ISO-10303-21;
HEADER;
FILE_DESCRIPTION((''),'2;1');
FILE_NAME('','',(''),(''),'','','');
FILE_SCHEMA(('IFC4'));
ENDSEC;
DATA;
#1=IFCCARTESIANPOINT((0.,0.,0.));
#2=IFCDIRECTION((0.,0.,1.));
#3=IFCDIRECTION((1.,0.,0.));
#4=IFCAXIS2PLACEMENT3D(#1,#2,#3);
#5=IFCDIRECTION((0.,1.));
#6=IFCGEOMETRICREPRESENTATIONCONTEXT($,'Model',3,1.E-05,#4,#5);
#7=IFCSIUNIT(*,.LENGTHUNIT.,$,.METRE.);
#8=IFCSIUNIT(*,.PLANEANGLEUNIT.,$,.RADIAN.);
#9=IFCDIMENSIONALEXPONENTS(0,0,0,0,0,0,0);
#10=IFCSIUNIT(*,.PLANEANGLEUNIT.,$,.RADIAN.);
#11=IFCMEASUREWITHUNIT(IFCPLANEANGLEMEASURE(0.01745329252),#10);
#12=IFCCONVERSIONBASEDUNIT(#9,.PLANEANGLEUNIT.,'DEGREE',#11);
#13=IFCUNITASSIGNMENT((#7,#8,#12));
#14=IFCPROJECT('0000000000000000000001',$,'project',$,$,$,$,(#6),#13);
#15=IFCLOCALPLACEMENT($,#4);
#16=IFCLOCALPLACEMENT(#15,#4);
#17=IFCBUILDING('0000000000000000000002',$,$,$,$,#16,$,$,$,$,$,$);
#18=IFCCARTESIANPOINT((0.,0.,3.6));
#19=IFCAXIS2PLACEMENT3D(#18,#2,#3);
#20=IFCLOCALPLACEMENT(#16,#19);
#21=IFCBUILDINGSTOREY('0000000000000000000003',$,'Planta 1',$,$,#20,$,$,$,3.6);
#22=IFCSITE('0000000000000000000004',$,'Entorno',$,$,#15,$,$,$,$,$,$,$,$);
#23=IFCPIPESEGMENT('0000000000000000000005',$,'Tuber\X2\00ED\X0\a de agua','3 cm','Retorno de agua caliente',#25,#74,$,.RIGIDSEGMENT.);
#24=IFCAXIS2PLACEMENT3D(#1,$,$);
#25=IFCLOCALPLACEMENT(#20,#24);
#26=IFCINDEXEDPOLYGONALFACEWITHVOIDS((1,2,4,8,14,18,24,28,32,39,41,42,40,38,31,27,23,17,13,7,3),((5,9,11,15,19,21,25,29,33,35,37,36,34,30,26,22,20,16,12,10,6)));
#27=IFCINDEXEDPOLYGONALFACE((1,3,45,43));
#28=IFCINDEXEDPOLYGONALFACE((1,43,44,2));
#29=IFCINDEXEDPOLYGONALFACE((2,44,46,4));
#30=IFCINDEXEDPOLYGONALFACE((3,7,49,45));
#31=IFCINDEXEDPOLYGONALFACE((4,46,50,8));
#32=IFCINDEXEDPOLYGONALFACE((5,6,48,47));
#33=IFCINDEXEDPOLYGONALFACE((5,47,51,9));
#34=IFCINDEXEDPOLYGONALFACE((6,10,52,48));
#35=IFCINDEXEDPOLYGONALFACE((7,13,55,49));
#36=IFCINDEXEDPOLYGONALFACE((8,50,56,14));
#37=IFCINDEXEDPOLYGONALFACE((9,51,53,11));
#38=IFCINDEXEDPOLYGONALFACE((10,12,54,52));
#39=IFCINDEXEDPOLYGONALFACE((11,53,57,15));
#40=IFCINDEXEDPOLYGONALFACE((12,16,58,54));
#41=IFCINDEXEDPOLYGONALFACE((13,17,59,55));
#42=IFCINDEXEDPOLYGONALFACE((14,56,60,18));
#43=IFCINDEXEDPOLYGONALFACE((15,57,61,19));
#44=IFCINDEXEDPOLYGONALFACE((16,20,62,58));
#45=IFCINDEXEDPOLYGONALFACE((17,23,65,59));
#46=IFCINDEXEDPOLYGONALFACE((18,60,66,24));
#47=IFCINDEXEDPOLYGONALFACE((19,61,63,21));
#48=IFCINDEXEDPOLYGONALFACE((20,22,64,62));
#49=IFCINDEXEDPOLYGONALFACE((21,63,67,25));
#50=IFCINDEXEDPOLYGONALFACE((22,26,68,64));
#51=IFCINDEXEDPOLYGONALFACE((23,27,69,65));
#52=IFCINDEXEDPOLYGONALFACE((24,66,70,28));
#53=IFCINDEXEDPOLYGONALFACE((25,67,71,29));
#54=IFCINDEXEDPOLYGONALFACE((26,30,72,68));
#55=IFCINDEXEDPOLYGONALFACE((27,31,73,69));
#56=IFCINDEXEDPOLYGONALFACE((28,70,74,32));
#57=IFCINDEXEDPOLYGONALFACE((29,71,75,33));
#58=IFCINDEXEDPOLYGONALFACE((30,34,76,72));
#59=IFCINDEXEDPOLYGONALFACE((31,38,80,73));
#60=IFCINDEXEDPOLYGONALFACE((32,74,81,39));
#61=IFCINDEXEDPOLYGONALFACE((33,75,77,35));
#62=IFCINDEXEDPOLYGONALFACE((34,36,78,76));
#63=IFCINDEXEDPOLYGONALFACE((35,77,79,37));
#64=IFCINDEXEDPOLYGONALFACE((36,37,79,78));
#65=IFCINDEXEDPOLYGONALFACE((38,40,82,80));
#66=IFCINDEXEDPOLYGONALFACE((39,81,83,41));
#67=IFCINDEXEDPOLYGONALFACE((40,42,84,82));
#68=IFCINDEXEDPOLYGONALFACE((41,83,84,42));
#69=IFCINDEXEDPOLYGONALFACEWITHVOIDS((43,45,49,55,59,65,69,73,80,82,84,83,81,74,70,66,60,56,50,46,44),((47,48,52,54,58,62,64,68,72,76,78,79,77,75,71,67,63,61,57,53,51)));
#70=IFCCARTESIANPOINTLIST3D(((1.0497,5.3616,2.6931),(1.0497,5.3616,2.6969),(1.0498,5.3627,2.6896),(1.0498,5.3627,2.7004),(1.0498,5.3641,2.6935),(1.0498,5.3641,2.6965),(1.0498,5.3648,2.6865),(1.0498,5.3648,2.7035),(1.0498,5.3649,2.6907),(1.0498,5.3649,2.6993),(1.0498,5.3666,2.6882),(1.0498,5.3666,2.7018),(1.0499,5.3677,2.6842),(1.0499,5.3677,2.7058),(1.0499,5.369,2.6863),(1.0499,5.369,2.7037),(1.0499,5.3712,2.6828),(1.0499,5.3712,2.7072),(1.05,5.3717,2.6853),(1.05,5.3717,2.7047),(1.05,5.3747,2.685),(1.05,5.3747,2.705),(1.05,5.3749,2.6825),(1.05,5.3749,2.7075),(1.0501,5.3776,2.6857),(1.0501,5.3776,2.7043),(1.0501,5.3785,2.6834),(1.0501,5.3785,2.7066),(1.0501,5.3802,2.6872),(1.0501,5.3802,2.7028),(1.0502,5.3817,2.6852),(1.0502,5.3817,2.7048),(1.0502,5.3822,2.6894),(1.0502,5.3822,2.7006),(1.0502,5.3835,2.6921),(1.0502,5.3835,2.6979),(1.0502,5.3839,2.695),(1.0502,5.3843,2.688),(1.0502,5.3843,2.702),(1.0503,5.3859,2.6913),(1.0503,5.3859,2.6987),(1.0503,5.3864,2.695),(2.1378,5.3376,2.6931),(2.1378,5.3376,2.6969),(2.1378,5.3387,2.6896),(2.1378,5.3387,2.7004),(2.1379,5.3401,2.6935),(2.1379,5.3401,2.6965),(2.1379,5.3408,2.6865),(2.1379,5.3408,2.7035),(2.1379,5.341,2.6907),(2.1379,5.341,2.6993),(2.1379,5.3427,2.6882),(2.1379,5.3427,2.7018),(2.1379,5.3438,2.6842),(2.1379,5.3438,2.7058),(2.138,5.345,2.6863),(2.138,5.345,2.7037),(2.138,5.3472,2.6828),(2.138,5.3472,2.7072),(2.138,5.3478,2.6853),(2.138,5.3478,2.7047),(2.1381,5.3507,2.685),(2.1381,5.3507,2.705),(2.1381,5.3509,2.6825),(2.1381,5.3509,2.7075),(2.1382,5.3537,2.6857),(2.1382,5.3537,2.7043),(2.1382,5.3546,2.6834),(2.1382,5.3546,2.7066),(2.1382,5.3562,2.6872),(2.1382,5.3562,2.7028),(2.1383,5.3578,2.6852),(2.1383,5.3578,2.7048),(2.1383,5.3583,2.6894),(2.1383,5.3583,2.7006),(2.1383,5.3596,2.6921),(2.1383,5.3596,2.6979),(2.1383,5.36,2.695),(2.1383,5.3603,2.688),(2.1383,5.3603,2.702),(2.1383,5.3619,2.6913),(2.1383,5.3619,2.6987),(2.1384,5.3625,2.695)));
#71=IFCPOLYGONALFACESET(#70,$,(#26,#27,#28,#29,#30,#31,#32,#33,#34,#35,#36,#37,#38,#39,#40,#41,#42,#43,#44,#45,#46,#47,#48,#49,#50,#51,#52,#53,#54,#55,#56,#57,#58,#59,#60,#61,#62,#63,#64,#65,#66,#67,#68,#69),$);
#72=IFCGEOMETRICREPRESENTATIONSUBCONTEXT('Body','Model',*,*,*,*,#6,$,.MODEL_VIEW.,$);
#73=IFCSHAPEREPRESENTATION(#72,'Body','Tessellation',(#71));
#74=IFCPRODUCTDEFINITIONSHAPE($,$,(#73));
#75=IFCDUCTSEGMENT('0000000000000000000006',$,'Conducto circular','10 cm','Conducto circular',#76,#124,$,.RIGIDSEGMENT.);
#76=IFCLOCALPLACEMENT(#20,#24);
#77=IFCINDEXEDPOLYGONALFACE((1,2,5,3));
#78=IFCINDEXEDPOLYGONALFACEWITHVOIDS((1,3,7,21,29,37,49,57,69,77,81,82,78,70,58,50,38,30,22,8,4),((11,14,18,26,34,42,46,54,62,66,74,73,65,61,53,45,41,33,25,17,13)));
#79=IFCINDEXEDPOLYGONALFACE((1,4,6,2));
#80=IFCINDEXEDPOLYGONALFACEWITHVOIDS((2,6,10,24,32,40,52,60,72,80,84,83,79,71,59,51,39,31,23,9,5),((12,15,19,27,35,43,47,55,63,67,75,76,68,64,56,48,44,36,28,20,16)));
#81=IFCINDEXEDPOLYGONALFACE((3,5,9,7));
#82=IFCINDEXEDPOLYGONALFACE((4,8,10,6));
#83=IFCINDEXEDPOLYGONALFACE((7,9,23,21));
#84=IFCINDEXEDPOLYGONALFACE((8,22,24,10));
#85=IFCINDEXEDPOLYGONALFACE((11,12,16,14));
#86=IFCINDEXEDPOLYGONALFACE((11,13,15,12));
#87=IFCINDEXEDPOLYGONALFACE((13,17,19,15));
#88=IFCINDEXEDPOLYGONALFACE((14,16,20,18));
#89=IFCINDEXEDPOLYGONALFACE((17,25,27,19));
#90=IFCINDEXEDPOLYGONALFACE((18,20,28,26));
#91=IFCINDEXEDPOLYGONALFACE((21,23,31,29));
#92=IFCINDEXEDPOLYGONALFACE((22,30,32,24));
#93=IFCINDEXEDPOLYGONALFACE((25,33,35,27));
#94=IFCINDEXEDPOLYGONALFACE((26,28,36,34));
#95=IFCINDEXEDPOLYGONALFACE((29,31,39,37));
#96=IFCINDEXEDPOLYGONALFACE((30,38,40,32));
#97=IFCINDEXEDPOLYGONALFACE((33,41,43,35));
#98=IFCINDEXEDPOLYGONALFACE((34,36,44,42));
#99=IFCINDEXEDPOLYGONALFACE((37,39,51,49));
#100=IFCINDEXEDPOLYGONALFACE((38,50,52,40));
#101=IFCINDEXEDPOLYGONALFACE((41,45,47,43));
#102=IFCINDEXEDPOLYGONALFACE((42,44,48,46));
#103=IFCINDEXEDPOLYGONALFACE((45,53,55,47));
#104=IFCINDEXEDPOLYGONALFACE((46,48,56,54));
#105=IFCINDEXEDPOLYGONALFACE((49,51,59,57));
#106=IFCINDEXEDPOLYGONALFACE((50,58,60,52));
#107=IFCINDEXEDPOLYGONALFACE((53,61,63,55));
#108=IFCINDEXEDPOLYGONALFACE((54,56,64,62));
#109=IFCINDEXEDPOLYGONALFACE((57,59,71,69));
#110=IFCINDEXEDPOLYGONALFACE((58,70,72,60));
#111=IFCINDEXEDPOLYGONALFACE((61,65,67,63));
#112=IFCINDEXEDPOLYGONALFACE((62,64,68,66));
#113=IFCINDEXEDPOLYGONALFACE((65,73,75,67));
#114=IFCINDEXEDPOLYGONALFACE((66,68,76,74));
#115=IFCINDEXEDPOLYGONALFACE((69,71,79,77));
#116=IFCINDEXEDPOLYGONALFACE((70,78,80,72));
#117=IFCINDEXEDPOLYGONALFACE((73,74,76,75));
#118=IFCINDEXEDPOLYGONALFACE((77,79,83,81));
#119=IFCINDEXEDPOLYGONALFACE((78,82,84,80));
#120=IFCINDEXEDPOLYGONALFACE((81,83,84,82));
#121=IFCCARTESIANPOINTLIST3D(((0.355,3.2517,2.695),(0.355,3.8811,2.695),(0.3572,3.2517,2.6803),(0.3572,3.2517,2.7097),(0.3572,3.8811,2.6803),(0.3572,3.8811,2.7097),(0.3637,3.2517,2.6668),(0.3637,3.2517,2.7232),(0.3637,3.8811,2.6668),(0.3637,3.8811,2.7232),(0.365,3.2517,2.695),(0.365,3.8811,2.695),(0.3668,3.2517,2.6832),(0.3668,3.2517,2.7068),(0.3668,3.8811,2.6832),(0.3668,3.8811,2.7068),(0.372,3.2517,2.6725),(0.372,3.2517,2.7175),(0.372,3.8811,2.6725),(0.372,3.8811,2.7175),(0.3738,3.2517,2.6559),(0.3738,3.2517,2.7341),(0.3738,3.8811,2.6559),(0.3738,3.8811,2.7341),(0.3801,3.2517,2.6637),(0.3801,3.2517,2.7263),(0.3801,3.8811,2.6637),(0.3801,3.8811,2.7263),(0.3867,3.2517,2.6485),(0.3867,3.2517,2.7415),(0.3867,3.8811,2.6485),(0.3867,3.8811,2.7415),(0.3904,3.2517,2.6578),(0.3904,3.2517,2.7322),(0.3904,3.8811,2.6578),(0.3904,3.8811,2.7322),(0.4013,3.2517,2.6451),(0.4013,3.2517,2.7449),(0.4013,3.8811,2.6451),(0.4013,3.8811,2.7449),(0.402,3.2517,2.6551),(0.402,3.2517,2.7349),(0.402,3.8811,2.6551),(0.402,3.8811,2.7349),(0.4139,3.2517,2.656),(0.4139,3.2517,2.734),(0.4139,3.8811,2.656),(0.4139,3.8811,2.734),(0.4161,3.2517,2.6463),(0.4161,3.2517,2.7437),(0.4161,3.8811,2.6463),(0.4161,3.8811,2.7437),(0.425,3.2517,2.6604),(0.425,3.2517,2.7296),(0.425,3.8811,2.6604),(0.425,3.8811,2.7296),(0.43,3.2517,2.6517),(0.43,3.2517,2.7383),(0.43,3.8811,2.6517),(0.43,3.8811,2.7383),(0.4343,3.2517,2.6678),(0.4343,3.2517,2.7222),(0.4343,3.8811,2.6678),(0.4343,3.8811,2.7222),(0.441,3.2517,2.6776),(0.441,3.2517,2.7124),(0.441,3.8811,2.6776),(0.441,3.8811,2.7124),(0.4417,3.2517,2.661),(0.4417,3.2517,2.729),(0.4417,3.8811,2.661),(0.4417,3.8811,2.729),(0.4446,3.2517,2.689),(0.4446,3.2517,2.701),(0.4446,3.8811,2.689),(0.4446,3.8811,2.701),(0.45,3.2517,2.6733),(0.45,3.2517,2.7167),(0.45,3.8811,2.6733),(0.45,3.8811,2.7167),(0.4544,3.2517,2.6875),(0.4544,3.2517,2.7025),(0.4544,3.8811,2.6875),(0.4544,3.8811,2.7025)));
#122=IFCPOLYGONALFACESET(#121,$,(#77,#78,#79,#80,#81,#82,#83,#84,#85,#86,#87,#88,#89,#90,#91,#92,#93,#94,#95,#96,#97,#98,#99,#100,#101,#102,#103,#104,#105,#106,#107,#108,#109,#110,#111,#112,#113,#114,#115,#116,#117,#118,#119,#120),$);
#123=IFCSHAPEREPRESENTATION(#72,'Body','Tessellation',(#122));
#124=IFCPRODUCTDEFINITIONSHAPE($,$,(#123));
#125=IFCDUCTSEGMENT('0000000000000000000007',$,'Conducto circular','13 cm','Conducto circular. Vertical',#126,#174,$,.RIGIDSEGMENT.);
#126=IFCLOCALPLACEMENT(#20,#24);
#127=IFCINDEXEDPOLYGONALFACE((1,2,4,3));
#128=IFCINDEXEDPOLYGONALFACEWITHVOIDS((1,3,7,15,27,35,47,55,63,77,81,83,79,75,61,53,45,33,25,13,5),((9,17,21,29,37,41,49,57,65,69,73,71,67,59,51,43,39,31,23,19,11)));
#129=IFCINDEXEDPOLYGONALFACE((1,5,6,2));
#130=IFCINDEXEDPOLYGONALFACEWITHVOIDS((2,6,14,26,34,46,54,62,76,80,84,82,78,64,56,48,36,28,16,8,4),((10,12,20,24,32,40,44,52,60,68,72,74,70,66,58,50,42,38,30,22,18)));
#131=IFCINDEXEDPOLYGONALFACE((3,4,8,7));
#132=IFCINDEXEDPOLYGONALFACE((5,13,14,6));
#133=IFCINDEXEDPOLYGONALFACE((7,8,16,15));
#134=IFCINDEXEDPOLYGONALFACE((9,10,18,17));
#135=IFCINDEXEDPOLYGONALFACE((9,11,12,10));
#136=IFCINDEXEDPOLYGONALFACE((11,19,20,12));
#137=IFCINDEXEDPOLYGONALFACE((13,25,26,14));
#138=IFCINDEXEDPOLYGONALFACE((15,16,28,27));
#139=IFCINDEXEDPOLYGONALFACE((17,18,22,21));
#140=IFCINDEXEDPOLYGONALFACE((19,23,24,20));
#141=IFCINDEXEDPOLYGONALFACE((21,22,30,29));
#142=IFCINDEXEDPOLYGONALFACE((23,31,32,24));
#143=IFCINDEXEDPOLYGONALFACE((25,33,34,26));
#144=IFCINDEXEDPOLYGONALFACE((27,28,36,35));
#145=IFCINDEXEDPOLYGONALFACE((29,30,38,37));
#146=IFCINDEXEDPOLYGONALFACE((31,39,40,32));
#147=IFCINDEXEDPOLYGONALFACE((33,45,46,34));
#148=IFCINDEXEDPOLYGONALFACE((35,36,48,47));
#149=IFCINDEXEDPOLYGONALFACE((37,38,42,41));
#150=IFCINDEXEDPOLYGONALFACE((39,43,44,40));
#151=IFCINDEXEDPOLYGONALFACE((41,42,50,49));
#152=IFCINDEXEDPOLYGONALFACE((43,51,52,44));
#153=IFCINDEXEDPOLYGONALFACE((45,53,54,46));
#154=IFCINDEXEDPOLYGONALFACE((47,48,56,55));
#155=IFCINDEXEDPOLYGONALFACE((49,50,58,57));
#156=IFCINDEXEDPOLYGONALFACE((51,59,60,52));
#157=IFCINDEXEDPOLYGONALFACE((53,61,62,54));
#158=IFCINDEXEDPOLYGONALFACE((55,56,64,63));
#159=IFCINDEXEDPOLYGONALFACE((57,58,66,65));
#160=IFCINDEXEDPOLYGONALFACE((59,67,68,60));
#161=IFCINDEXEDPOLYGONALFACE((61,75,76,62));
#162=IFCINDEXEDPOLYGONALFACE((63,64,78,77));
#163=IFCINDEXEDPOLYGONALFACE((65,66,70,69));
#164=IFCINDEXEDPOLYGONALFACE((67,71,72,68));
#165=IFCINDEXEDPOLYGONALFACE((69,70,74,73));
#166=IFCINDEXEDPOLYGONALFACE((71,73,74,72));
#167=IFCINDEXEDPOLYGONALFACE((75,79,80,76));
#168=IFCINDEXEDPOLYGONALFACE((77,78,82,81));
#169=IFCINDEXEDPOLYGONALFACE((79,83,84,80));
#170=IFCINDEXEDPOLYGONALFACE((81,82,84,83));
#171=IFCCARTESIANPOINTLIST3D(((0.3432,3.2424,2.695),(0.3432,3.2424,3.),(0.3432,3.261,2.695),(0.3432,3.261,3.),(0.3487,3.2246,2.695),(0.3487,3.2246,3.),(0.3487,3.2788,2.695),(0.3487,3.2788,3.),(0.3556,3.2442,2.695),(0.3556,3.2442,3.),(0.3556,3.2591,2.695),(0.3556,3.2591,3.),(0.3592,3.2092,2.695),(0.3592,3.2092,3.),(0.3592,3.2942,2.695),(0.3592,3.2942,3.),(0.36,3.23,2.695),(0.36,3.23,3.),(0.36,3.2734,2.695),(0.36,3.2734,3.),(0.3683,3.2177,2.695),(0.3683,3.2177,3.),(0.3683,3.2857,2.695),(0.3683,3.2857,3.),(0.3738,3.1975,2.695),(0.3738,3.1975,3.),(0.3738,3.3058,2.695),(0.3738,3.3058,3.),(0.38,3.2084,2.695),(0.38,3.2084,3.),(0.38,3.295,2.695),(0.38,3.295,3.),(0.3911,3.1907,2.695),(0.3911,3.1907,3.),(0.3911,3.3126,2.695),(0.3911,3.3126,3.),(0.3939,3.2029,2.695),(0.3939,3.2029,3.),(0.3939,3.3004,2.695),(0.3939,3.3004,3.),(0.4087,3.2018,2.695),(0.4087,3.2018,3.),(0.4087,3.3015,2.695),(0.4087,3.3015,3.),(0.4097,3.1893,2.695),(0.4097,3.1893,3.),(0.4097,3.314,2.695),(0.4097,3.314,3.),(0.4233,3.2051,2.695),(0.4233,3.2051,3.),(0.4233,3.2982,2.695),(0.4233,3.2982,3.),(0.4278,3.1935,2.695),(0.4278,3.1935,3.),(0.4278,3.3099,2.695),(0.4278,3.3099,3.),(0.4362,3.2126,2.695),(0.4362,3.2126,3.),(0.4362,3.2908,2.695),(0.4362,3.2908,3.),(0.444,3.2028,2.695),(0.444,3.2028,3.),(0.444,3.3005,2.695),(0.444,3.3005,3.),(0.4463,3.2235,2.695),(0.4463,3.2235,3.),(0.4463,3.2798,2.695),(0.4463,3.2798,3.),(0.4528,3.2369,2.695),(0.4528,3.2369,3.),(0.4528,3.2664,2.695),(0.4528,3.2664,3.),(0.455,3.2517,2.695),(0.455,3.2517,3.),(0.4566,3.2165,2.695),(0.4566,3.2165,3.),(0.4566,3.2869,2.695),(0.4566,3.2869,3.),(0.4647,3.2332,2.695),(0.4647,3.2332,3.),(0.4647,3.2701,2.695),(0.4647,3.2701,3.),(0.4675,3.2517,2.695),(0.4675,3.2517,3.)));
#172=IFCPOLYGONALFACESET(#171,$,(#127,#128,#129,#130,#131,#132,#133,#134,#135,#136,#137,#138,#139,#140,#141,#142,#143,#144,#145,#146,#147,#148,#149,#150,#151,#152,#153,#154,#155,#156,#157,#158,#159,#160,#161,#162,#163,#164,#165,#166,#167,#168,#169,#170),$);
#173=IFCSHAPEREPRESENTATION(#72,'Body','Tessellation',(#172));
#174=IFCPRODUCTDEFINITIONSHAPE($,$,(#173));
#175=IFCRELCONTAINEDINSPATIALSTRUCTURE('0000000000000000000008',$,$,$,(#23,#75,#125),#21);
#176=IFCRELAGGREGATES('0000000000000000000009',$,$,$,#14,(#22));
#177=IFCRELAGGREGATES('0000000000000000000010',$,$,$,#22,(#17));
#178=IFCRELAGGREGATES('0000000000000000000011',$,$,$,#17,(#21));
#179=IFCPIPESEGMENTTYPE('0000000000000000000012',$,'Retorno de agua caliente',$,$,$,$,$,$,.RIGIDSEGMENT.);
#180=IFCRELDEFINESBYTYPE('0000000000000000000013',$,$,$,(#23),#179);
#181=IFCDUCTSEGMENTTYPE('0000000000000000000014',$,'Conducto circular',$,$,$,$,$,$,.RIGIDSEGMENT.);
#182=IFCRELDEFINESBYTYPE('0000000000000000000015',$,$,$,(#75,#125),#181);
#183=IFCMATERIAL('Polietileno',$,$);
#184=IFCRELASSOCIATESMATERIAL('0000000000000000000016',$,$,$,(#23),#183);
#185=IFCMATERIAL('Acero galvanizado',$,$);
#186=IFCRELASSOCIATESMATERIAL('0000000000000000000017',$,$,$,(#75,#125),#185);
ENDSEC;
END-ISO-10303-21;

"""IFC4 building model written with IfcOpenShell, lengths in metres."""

from ifc_helpers import new_model, entity, si_unit, converted_unit, direction, frame, origin_with_axes, origin_2d_with_axis, place, context, subcontext, project, spatial, hollow_circle, extrude, material, type_object, element, save


model = new_model("IFC4")

# Units and contexts
model_context = context("Model", 3, precision=1e-05, world=origin_with_axes(), true_north=direction((0.0, 1.0)))
body_context = subcontext(model_context, "Body", "Model", "MODEL_VIEW")
ifc_project = project(units=[si_unit("LENGTHUNIT", "METRE"), si_unit("PLANEANGLEUNIT", "RADIAN"), converted_unit("PLANEANGLEUNIT", "DEGREE", entity("IfcPlaneAngleMeasure", 0.01745329252), si_unit("PLANEANGLEUNIT", "RADIAN"), dimensions=[0, 0, 0, 0, 0, 0, 0])], contexts=[model_context])

# Site, building, storey
site_placement = place(None, origin_with_axes())
site = spatial("IfcSite", under=ifc_project, at=site_placement, Name="Entorno")
building_placement = place(site_placement, origin_with_axes())
building = spatial("IfcBuilding", under=site, at=building_placement)
storey_placement = place(building_placement, frame((0.0, 0.0, 3.6), z_axis=(0.0, 0.0, 1.0), x_axis=(1.0, 0.0, 0.0)))
storey = spatial("IfcBuildingStorey", under=building, at=storey_placement, Name="Planta 1", Elevation=3.6)

# Pipe segment
ifc_material_1 = material(Name="Polietileno")
pipe_segment_type_1 = type_object("IfcPipeSegmentType", Name="Retorno de agua caliente", PredefinedType="RIGIDSEGMENT")
pipe_segment_1_placement = place(storey_placement, frame((1.05, 5.374, 2.695), z_axis=(0.999758, -0.022006, 0.0), x_axis=(0.022006, 0.999758, 0.0)))
element("IfcPipeSegment", 1, at=pipe_segment_1_placement, inside=storey, type_object=pipe_segment_type_1, material=ifc_material_1, Name="Tubería de agua", Description="3 cm", ObjectType="Retorno de agua caliente", PredefinedType="RIGIDSEGMENT", context=body_context, shape_type="SweptSolid", body=[
    extrude(hollow_circle(Radius=0.0125, WallThickness=0.0025, at=origin_2d_with_axis()), origin_with_axes(), (0.0, 0.0, 1.0), 1.0883),
])

# Duct segments
ifc_material_2 = material(Name="Acero galvanizado")
duct_segment_type = type_object("IfcDuctSegmentType", Name="Conducto circular", PredefinedType="RIGIDSEGMENT")
duct_segment_1_placement = place(storey_placement, frame((0.405, 3.2517, 2.695), z_axis=(0.0, 1.0, 0.0), x_axis=(-1.0, 0.0, 0.0)))
element("IfcDuctSegment", 2, at=duct_segment_1_placement, inside=storey, type_object=duct_segment_type, material=ifc_material_2, Name="Conducto circular", Description="10 cm", ObjectType="Conducto circular", PredefinedType="RIGIDSEGMENT", context=body_context, shape_type="SweptSolid", body=[
    extrude(hollow_circle(Radius=0.05, WallThickness=0.01, at=origin_2d_with_axis()), origin_with_axes(), (0.0, 0.0, 1.0), 0.6294),
])
duct_segment_2_placement = place(storey_placement, frame((0.405, 3.2517, 2.695), z_axis=(0.0, 0.0, 1.0), x_axis=(1.0, 0.0, 0.0)))
element("IfcDuctSegment", 3, at=duct_segment_2_placement, inside=storey, type_object=duct_segment_type, material=ifc_material_2, Name="Conducto circular", Description="13 cm", ObjectType="Conducto circular. Vertical", PredefinedType="RIGIDSEGMENT", context=body_context, shape_type="SweptSolid", body=[
    extrude(hollow_circle(Radius=0.0625, WallThickness=0.0125, at=origin_2d_with_axis()), origin_with_axes(), (0.0, 0.0, 1.0), 0.305),
])

save(model, "model.ifc")
